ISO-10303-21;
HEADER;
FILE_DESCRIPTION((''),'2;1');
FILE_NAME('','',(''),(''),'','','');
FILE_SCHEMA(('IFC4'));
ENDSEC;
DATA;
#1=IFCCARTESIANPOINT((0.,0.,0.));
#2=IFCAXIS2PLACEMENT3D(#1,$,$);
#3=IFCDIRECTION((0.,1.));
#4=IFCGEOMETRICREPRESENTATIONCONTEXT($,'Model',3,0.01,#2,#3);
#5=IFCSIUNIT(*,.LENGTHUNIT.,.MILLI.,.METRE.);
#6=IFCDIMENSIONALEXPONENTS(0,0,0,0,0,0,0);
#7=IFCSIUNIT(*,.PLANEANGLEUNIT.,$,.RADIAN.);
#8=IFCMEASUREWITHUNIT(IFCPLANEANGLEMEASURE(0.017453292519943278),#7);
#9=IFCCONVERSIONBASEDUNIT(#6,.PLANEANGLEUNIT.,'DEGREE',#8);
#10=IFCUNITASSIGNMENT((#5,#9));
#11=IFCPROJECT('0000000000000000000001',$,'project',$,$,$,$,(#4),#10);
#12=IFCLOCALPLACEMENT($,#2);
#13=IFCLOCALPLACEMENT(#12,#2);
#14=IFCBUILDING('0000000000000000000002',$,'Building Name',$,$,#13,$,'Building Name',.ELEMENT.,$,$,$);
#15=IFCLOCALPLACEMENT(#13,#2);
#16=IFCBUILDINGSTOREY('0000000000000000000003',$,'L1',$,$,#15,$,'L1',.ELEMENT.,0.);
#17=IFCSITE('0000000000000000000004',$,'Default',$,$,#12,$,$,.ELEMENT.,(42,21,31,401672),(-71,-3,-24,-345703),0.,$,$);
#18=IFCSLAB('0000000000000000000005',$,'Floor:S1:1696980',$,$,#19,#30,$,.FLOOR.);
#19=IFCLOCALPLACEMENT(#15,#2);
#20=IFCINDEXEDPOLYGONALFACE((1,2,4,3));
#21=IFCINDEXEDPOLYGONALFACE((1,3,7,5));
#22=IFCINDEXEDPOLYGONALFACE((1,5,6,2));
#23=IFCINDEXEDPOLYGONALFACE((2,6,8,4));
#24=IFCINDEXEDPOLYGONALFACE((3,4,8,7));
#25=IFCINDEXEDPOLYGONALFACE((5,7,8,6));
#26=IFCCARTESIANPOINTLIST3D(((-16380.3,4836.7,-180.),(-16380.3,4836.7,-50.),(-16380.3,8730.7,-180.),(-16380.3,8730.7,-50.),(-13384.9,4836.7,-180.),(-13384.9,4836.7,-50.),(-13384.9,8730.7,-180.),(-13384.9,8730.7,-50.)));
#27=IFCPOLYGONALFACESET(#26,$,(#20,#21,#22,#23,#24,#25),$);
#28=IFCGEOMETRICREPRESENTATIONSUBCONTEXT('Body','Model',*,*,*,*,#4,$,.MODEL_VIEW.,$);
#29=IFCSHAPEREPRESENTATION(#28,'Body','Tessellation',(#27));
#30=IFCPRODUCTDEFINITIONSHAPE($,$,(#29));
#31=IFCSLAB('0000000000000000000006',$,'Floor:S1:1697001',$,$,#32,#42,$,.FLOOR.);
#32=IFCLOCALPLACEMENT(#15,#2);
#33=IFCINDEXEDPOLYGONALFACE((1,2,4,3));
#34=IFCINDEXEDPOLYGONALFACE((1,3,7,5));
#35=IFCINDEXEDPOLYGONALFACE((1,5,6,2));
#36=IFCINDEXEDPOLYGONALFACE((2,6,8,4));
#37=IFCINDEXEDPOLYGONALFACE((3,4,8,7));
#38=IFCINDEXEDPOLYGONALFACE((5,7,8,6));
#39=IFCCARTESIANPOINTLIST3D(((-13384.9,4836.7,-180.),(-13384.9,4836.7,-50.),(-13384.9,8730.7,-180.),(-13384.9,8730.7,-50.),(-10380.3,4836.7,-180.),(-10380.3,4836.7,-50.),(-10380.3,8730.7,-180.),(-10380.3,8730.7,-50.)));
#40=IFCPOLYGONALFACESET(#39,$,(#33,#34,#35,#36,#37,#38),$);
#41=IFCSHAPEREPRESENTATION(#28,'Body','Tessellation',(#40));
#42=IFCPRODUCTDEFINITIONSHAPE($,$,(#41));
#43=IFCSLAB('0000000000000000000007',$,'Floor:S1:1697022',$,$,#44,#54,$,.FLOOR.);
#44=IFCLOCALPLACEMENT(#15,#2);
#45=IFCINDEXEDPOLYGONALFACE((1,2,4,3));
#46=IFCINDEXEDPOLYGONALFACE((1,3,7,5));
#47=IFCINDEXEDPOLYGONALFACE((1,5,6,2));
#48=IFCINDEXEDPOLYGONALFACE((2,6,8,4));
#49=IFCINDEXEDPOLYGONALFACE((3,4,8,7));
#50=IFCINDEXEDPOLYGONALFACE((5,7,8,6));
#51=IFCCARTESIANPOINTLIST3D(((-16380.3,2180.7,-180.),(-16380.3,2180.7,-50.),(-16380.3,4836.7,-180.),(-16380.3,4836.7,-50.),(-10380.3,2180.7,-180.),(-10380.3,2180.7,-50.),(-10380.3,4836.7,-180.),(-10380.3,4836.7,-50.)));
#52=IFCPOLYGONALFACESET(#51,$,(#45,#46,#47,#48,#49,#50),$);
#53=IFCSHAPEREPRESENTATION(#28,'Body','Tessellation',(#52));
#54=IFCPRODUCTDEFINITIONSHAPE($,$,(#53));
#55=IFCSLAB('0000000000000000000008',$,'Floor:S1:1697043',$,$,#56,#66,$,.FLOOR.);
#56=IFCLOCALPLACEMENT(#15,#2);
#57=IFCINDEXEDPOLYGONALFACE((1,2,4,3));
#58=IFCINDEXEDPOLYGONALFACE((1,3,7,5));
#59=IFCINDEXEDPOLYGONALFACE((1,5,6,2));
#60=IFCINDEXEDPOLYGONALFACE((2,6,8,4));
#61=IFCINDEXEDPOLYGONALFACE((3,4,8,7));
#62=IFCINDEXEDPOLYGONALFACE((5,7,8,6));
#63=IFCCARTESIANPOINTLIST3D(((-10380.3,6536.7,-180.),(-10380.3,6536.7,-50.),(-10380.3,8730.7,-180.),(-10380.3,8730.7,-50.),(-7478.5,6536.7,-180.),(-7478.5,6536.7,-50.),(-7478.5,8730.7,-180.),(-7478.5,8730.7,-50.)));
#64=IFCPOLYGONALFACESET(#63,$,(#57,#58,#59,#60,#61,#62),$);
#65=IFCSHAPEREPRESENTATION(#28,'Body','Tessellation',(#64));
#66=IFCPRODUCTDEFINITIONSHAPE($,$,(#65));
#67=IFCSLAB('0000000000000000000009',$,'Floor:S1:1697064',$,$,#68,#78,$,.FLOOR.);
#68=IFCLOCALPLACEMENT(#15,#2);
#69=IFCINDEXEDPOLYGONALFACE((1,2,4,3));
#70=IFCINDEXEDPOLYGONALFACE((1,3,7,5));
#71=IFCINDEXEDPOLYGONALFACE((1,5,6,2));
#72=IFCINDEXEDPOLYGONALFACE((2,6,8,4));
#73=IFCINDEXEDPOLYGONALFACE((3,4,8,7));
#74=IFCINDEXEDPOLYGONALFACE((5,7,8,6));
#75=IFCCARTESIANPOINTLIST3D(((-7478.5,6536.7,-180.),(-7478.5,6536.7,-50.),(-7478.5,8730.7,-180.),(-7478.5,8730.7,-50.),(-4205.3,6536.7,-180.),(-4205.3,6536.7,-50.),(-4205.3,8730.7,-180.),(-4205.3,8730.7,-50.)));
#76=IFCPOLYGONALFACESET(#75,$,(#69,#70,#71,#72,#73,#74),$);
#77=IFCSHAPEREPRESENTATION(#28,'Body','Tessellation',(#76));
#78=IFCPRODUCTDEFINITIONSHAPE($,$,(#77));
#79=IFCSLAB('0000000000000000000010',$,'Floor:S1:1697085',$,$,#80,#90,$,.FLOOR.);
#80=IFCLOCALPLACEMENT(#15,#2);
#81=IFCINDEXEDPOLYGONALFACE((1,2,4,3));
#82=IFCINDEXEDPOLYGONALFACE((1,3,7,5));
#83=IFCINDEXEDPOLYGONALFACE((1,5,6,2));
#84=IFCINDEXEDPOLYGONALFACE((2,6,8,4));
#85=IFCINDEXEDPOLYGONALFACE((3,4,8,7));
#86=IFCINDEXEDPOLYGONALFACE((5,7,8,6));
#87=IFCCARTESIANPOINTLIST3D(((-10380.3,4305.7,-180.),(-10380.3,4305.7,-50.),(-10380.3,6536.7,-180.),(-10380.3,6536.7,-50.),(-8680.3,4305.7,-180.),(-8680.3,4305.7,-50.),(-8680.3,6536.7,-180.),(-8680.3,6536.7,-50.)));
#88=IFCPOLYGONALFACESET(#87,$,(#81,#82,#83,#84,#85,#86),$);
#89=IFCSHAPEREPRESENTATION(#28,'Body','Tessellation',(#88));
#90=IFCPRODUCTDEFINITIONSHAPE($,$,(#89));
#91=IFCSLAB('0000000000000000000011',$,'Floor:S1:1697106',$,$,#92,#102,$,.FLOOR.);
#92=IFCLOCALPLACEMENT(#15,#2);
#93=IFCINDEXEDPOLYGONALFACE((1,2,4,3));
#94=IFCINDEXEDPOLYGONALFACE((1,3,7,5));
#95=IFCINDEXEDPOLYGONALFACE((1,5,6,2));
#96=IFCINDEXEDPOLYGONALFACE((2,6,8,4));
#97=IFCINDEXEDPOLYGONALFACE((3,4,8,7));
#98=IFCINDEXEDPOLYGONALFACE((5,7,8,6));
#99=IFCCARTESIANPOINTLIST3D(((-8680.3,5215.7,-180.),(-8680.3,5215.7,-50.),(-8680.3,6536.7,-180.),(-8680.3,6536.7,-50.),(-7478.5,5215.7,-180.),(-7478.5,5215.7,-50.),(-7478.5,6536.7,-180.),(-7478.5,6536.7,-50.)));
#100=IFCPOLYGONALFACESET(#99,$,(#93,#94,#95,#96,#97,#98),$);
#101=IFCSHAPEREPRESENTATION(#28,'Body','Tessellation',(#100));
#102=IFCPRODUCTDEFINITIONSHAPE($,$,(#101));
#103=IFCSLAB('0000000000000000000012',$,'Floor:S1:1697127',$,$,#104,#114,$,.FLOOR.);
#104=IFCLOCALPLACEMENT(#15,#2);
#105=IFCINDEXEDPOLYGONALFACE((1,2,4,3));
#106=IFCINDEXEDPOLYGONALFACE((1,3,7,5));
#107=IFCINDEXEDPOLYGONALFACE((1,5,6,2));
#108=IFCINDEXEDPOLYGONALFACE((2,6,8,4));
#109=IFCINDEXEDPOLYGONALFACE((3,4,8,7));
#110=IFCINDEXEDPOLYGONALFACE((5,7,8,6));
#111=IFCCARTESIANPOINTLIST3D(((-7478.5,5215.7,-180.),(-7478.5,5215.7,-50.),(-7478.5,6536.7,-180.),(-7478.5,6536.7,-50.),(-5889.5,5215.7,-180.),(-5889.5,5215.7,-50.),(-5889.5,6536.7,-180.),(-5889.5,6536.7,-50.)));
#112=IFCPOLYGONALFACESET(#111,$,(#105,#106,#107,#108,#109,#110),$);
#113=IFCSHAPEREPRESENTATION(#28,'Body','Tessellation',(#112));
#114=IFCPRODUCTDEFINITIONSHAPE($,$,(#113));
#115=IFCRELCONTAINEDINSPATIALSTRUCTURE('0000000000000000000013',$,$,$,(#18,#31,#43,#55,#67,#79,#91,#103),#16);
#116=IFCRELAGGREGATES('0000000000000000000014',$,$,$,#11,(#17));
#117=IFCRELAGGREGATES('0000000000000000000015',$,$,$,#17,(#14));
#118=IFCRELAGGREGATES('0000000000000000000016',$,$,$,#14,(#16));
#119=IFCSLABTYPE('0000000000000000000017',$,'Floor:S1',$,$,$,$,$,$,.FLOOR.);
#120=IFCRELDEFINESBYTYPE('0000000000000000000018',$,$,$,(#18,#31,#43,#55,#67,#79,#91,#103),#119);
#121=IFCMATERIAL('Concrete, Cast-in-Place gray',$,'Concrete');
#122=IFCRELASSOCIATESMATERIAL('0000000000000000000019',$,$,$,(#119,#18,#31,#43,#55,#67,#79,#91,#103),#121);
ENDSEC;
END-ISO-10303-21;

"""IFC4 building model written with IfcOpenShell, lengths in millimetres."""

from ifc_helpers import new_model, entity, si_unit, converted_unit, direction, frame, origin, place, context, subcontext, project, spatial, indexed_curve, outline, extrude, material, type_object, element, save


model = new_model("IFC4")

# Units and contexts
model_context = context("Model", 3, precision=0.01, world=origin(), true_north=direction((0.0, 1.0)))
body_context = subcontext(model_context, "Body", "Model", "MODEL_VIEW")
ifc_project = project(units=[si_unit("LENGTHUNIT", "METRE", prefix="MILLI"), converted_unit("PLANEANGLEUNIT", "DEGREE", entity("IfcPlaneAngleMeasure", 0.017453292519943278), si_unit("PLANEANGLEUNIT", "RADIAN"), dimensions=[0, 0, 0, 0, 0, 0, 0])], contexts=[model_context])

# Site, building, storey
site_placement = place(None, origin())
site = spatial("IfcSite", under=ifc_project, at=site_placement, Name="Default", CompositionType="ELEMENT", RefLatitude=(42, 21, 31, 401672), RefLongitude=(-71, -3, -24, -345703), RefElevation=0.0)
building_placement = place(site_placement, origin())
building = spatial("IfcBuilding", under=site, at=building_placement, Name="Building Name", LongName="Building Name", CompositionType="ELEMENT")
storey_placement = place(building_placement, origin())
storey = spatial("IfcBuildingStorey", under=building, at=storey_placement, Name="L1", LongName="L1", CompositionType="ELEMENT", Elevation=0.0)

# Shared definitions
ifc_material = material(Name="Concrete, Cast-in-Place gray", Category="Concrete")

# Slabs
slab_type = type_object("IfcSlabType", Name="Floor:S1", PredefinedType="FLOOR", material=ifc_material)
slab_1_placement = place(storey_placement, origin())
element("IfcSlab", 1, at=slab_1_placement, inside=storey, type_object=slab_type, material=ifc_material, Name="Floor:S1:1696980", PredefinedType="FLOOR", context=body_context, shape_type="SweptSolid", body=[
    extrude(outline(indexed_curve([(-1947.0, -1497.7), (1947.0, -1497.7), (1947.0, 1497.7), (-1947.0, 1497.7), (-1947.0, -1497.7)], self_intersect=False)), frame((-14882.6, 6783.7, -50.0), z_axis=(0.0, 0.0, -1.0), x_axis=(0.0, 1.0, 0.0)), (0.0, 0.0, 1.0), 130.0),
])
slab_2_placement = place(storey_placement, origin())
element("IfcSlab", 2, at=slab_2_placement, inside=storey, type_object=slab_type, material=ifc_material, Name="Floor:S1:1697001", PredefinedType="FLOOR", context=body_context, shape_type="SweptSolid", body=[
    extrude(outline(indexed_curve([(-1947.0, -1502.3), (1947.0, -1502.3), (1947.0, 1502.3), (-1947.0, 1502.3), (-1947.0, -1502.3)], self_intersect=False)), frame((-11882.6, 6783.7, -50.0), z_axis=(0.0, 0.0, -1.0), x_axis=(0.0, 1.0, 0.0)), (0.0, 0.0, 1.0), 130.0),
])
slab_3_placement = place(storey_placement, origin())
element("IfcSlab", 3, at=slab_3_placement, inside=storey, type_object=slab_type, material=ifc_material, Name="Floor:S1:1697022", PredefinedType="FLOOR", context=body_context, shape_type="SweptSolid", body=[
    extrude(outline(indexed_curve([(-1328.0, -3000.0), (1328.0, -3000.0), (1328.0, 3000.0), (-1328.0, 3000.0), (-1328.0, -3000.0)], self_intersect=False)), frame((-13380.3, 3508.7, -50.0), z_axis=(0.0, 0.0, -1.0), x_axis=(0.0, 1.0, 0.0)), (0.0, 0.0, 1.0), 130.0),
])
slab_4_placement = place(storey_placement, origin())
element("IfcSlab", 4, at=slab_4_placement, inside=storey, type_object=slab_type, material=ifc_material, Name="Floor:S1:1697043", PredefinedType="FLOOR", context=body_context, shape_type="SweptSolid", body=[
    extrude(outline(indexed_curve([(-1097.0, -1450.9), (1097.0, -1450.9), (1097.0, 1450.9), (-1097.0, 1450.9), (-1097.0, -1450.9)], self_intersect=False)), frame((-8929.4, 7633.7, -50.0), z_axis=(0.0, 0.0, -1.0), x_axis=(0.0, 1.0, 0.0)), (0.0, 0.0, 1.0), 130.0),
])
slab_5_placement = place(storey_placement, origin())
element("IfcSlab", 5, at=slab_5_placement, inside=storey, type_object=slab_type, material=ifc_material, Name="Floor:S1:1697064", PredefinedType="FLOOR", context=body_context, shape_type="SweptSolid", body=[
    extrude(outline(indexed_curve([(-1097.0, -1636.6), (1097.0, -1636.6), (1097.0, 1636.6), (-1097.0, 1636.6), (-1097.0, -1636.6)], self_intersect=False)), frame((-5841.9, 7633.7, -50.0), z_axis=(0.0, 0.0, -1.0), x_axis=(0.0, 1.0, 0.0)), (0.0, 0.0, 1.0), 130.0),
])
slab_6_placement = place(storey_placement, origin())
element("IfcSlab", 6, at=slab_6_placement, inside=storey, type_object=slab_type, material=ifc_material, Name="Floor:S1:1697085", PredefinedType="FLOOR", context=body_context, shape_type="SweptSolid", body=[
    extrude(outline(indexed_curve([(-1115.5, -850.0), (1115.5, -850.0), (1115.5, 850.0), (-1115.5, 850.0), (-1115.5, -850.0)], self_intersect=False)), frame((-9530.3, 5421.2, -50.0), z_axis=(0.0, 0.0, -1.0), x_axis=(0.0, 1.0, 0.0)), (0.0, 0.0, 1.0), 130.0),
])
slab_7_placement = place(storey_placement, origin())
element("IfcSlab", 7, at=slab_7_placement, inside=storey, type_object=slab_type, material=ifc_material, Name="Floor:S1:1697106", PredefinedType="FLOOR", context=body_context, shape_type="SweptSolid", body=[
    extrude(outline(indexed_curve([(-660.5, -600.9), (660.5, -600.9), (660.5, 600.9), (-660.5, 600.9), (-660.5, -600.9)], self_intersect=False)), frame((-8079.4, 5876.2, -50.0), z_axis=(0.0, 0.0, -1.0), x_axis=(0.0, 1.0, 0.0)), (0.0, 0.0, 1.0), 130.0),
])
slab_8_placement = place(storey_placement, origin())
element("IfcSlab", 8, at=slab_8_placement, inside=storey, type_object=slab_type, material=ifc_material, Name="Floor:S1:1697127", PredefinedType="FLOOR", context=body_context, shape_type="SweptSolid", body=[
    extrude(outline(indexed_curve([(-660.5, -794.5), (660.5, -794.5), (660.5, 794.5), (-660.5, 794.5), (-660.5, -794.5)], self_intersect=False)), frame((-6684.0, 5876.2, -50.0), z_axis=(0.0, 0.0, -1.0), x_axis=(0.0, 1.0, 0.0)), (0.0, 0.0, 1.0), 130.0),
])

save(model, "model.ifc")
